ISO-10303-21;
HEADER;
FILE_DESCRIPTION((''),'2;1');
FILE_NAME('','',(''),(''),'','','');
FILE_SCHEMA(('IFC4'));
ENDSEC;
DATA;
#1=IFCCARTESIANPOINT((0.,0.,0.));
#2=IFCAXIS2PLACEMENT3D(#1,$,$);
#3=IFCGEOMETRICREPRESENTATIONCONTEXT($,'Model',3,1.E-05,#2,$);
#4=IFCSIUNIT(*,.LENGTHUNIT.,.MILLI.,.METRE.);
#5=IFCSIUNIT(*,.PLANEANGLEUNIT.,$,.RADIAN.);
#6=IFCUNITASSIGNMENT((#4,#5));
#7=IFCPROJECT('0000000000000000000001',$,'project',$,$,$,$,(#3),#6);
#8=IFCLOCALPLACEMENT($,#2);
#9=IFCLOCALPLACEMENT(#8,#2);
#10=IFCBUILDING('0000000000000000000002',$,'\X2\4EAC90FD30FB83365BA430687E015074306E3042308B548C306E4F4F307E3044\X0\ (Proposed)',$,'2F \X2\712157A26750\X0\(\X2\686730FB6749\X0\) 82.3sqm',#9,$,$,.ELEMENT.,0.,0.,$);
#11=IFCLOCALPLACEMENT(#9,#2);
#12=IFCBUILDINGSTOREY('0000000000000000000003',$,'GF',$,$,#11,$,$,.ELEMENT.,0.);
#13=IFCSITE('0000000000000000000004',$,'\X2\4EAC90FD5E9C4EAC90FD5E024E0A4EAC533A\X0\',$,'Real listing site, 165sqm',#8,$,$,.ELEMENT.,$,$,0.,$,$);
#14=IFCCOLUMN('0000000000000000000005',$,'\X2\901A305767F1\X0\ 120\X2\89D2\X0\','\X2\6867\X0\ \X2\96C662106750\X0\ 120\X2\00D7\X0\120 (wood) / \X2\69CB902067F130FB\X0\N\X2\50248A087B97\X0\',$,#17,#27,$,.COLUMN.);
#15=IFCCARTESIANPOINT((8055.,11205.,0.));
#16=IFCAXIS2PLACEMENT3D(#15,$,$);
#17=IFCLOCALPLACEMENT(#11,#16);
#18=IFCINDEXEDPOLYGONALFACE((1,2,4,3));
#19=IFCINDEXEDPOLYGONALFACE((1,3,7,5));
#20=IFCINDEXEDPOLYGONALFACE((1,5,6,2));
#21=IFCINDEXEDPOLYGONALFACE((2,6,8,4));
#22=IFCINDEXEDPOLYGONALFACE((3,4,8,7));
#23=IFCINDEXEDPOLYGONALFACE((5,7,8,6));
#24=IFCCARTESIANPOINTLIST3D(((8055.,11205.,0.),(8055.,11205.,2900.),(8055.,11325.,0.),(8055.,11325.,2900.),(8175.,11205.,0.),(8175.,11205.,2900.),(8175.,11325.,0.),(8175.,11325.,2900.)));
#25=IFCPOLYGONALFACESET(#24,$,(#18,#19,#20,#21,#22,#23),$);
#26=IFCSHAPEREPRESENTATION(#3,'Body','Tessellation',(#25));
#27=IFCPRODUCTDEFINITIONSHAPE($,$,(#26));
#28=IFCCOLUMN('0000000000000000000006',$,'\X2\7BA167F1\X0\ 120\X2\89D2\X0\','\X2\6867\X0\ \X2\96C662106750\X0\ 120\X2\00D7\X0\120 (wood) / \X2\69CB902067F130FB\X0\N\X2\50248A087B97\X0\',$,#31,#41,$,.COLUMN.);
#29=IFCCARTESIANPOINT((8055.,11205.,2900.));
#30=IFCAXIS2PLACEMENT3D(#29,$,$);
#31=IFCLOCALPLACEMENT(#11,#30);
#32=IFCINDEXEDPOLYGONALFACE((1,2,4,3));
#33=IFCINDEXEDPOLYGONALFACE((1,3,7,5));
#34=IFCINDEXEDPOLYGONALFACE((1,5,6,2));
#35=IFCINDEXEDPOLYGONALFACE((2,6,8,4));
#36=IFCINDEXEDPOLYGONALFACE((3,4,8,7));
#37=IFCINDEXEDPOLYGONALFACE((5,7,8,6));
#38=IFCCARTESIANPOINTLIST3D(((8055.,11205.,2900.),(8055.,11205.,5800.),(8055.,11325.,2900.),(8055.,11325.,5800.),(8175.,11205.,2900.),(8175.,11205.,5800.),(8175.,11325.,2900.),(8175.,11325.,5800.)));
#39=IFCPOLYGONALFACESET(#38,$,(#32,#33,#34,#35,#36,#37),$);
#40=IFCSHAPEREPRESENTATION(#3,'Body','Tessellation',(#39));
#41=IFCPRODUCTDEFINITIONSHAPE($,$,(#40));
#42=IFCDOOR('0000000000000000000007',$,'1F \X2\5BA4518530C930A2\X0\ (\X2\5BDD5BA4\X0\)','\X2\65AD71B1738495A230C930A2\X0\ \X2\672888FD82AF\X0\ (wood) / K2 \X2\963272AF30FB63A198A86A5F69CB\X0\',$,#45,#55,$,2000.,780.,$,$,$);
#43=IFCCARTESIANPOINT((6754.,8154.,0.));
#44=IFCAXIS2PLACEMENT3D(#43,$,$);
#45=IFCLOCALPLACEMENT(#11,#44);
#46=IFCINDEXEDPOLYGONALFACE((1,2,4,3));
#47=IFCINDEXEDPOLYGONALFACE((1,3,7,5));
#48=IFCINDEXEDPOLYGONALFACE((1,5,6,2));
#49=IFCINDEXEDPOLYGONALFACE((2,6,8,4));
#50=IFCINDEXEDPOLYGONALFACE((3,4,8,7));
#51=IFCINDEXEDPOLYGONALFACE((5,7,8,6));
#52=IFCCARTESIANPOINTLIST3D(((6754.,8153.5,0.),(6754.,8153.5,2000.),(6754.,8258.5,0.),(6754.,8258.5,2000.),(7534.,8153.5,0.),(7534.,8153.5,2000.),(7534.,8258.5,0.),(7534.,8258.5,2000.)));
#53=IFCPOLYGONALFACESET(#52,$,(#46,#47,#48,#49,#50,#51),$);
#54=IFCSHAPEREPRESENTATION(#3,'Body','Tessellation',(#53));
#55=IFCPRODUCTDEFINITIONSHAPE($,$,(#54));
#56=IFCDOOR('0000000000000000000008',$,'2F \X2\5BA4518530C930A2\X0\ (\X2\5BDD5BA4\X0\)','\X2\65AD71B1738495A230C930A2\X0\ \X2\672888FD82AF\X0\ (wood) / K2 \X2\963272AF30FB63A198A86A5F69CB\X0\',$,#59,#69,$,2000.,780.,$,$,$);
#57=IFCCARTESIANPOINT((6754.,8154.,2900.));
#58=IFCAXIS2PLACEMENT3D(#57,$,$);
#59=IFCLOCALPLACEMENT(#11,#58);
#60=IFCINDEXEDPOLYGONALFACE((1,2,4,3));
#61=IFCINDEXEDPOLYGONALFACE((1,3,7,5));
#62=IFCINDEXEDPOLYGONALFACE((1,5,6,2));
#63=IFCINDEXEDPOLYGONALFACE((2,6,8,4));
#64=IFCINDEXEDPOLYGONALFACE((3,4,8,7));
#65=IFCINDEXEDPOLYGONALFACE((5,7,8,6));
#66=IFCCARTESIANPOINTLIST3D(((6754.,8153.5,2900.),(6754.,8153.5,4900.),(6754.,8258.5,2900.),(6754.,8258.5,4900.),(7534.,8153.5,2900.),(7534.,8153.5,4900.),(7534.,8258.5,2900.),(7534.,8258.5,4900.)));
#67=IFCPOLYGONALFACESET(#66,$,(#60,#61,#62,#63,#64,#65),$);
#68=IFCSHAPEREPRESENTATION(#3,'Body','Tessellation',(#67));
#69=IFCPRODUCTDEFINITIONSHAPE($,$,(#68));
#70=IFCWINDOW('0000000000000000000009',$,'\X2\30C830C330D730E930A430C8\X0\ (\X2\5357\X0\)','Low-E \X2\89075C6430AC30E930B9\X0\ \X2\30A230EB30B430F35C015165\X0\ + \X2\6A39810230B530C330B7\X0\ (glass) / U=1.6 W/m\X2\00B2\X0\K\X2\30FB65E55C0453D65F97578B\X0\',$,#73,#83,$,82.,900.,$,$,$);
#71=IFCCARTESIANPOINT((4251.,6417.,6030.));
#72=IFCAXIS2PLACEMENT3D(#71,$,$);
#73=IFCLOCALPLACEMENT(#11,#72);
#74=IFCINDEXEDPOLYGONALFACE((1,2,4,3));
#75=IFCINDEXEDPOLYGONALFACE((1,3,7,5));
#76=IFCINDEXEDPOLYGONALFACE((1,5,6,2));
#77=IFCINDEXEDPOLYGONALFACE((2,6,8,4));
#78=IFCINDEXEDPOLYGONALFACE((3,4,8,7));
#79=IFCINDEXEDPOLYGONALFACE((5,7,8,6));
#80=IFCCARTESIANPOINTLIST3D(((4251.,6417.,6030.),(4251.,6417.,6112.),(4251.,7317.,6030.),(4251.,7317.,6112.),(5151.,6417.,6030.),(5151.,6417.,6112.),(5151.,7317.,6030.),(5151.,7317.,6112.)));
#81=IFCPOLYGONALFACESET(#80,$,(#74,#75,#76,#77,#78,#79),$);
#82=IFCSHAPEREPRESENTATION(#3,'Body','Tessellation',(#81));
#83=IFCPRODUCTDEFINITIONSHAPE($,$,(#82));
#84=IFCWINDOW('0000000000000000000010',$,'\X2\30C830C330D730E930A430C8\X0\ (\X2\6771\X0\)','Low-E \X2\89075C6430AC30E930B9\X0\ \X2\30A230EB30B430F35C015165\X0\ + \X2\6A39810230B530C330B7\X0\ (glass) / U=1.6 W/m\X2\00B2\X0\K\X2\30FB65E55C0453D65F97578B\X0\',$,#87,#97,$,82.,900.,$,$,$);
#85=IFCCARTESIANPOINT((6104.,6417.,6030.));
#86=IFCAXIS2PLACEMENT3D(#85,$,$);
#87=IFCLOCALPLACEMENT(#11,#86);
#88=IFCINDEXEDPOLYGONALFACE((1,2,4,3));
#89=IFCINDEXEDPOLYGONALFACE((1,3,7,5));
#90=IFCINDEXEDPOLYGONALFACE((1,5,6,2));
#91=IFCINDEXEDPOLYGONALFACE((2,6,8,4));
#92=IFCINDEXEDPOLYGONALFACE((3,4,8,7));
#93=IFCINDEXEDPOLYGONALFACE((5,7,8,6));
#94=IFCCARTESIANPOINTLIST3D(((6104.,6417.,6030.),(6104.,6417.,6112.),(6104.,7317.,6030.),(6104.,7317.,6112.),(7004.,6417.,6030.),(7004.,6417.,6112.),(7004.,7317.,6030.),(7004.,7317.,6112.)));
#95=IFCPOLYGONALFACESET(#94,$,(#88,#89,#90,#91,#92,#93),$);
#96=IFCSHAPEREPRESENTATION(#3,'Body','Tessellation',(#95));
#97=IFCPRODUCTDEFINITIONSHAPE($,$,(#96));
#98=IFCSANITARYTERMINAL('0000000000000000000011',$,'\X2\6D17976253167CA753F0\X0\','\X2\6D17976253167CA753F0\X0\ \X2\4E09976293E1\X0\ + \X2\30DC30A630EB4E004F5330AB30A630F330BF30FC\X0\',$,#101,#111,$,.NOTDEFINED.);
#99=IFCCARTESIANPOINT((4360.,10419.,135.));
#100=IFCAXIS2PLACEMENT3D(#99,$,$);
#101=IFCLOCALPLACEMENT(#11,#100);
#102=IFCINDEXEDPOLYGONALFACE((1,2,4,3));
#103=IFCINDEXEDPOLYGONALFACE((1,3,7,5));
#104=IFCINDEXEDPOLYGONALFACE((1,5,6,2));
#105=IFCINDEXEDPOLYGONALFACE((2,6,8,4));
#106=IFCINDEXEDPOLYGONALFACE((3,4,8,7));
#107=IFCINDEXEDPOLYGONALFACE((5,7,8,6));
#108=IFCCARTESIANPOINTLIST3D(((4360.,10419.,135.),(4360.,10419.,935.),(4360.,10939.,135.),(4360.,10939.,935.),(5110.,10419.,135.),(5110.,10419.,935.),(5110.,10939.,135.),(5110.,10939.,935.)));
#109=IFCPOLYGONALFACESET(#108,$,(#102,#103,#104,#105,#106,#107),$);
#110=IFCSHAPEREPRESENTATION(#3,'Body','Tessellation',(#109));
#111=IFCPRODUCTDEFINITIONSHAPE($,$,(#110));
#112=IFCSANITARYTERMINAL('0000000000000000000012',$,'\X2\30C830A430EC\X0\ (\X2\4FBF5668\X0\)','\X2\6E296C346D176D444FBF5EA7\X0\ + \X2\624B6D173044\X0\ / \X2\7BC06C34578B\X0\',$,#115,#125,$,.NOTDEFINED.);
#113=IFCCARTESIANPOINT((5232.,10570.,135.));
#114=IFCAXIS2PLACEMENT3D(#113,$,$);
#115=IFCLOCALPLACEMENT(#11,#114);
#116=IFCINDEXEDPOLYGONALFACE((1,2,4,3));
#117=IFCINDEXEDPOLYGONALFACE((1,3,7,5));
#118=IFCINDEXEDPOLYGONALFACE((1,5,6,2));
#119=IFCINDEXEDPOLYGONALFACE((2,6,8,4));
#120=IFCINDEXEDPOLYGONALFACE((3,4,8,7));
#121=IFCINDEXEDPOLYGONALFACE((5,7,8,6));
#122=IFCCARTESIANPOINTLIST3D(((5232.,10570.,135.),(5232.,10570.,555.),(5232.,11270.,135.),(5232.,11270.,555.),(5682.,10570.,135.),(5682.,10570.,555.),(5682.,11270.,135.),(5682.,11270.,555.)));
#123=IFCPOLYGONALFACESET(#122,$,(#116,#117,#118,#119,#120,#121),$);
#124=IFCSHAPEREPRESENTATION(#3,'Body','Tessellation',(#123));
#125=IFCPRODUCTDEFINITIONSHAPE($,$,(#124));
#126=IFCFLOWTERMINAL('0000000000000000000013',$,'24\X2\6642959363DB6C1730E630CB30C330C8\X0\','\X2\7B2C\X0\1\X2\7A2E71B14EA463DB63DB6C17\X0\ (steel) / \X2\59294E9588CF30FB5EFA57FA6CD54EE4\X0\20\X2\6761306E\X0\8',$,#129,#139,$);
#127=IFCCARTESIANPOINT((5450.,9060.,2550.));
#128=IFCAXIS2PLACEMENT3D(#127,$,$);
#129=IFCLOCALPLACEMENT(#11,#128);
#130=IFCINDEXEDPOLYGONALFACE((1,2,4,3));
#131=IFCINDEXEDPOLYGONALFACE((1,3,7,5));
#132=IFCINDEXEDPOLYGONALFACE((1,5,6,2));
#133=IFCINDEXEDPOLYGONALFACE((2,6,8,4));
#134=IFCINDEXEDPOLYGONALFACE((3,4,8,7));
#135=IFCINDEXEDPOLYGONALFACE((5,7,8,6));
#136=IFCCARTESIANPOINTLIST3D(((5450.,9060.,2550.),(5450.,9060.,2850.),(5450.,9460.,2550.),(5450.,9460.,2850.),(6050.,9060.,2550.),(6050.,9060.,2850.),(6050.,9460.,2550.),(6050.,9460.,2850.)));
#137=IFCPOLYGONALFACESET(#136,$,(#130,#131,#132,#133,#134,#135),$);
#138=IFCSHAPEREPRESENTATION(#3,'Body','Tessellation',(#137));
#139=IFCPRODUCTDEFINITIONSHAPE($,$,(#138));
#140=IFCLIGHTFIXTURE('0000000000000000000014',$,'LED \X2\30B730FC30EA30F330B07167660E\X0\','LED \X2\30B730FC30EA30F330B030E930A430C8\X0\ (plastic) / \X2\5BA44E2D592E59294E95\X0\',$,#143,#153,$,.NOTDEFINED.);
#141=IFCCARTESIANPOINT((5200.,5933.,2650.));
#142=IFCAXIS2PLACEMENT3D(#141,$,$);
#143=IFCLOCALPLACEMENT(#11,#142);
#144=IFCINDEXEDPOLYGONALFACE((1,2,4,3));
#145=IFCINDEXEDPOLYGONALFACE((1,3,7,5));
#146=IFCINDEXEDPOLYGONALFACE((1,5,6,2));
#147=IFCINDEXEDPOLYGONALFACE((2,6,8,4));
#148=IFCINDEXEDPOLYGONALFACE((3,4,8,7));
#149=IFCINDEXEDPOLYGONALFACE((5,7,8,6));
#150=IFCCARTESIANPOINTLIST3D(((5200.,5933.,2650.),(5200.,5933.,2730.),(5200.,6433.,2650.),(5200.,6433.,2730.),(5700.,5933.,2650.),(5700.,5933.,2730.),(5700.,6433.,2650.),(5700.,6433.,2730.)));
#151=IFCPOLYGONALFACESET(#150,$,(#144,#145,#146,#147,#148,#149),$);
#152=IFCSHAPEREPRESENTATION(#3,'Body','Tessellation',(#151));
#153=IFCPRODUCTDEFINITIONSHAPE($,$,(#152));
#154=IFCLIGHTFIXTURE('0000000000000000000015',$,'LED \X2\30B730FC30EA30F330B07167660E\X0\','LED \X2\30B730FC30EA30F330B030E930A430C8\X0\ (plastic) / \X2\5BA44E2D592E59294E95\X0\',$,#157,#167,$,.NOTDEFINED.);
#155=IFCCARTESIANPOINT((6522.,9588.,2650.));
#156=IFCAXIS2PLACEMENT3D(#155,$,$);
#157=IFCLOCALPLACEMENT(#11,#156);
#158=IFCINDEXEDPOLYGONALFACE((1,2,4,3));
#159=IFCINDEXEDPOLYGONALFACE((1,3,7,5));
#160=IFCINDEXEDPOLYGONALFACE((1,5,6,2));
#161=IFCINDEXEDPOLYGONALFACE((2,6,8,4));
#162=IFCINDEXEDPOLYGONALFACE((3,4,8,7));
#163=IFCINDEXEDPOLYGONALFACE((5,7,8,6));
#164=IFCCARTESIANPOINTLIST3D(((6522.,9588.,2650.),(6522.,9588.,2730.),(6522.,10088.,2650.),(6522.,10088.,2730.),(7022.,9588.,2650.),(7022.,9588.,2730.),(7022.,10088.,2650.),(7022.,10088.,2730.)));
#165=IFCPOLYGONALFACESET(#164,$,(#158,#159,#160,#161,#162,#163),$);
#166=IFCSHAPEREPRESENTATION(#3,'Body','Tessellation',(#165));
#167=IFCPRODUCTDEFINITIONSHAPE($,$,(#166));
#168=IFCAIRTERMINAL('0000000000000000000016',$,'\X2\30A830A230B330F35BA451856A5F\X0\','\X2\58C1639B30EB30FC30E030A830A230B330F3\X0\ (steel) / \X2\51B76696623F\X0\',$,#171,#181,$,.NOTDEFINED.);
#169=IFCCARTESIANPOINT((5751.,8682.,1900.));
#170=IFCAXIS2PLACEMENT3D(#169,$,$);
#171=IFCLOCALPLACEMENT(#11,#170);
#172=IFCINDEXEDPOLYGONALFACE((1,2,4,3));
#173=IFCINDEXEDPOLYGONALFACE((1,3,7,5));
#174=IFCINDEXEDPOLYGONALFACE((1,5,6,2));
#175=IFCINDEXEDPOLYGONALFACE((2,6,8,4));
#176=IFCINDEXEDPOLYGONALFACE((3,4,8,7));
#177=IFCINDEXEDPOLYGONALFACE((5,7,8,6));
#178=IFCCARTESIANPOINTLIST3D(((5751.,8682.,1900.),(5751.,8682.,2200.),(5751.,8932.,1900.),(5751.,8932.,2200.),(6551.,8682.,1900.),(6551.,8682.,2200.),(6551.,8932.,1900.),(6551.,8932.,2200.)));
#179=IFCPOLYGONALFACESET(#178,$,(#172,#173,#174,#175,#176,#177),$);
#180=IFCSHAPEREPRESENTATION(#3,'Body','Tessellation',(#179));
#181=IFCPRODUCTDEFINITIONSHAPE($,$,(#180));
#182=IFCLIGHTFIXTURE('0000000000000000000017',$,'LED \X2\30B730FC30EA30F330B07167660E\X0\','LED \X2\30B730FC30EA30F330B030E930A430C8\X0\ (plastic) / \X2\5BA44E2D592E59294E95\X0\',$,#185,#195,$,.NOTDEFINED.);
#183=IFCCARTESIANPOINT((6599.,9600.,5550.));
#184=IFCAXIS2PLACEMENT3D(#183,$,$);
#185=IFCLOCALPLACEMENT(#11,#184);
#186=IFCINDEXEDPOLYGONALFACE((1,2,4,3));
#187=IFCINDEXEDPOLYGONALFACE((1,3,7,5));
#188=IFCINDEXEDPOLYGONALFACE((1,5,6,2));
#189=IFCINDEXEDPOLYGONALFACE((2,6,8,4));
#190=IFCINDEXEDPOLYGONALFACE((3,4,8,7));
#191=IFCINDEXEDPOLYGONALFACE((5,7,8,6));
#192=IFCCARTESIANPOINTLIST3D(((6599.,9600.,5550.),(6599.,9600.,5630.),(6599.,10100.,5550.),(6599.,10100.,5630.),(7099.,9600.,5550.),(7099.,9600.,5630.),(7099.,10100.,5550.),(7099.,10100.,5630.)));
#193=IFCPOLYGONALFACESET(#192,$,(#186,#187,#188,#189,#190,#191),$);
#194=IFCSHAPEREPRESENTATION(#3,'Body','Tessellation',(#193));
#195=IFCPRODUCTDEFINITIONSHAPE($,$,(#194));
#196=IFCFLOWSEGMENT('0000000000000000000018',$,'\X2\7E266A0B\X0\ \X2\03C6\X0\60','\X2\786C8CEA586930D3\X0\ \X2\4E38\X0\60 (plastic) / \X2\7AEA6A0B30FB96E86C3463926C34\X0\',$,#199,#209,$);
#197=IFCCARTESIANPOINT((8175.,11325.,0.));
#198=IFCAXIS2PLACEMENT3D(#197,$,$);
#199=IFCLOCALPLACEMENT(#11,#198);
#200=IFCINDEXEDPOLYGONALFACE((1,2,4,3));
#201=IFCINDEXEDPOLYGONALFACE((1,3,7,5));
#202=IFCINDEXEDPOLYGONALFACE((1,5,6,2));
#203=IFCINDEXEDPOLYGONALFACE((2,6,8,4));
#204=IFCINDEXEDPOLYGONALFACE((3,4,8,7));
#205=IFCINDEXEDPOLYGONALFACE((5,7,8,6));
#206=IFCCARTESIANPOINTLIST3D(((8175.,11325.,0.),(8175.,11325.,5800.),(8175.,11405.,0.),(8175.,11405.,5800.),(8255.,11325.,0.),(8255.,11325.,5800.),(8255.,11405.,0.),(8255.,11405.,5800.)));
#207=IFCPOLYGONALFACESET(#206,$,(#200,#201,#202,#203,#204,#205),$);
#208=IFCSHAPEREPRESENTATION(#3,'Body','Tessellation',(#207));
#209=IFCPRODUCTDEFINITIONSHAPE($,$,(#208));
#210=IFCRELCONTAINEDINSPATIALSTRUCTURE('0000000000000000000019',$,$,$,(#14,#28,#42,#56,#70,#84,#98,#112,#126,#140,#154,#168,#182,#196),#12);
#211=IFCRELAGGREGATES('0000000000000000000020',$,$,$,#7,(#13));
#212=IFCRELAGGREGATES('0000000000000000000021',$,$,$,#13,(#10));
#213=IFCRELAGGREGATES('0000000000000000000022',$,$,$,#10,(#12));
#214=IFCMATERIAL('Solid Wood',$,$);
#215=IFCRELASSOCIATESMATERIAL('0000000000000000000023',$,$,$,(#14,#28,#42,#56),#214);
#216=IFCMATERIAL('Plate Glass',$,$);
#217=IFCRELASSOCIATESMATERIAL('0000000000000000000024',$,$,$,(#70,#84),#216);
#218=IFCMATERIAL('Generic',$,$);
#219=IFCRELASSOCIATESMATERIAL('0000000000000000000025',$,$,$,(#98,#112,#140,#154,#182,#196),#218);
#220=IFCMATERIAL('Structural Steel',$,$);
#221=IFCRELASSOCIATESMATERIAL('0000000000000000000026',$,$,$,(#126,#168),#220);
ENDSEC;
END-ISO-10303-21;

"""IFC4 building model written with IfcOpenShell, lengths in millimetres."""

from ifc_helpers import new_model, si_unit, frame, frame_2d, origin, place, context, project, spatial, rectangle, extrude, material, element, save


model = new_model("IFC4")

# Units and contexts
model_context = context("Model", 3, precision=1e-05, world=origin())
ifc_project = project(units=[si_unit("LENGTHUNIT", "METRE", prefix="MILLI"), si_unit("PLANEANGLEUNIT", "RADIAN")], contexts=[model_context])

# Site, building, storey
site_placement = place(None, origin())
site = spatial("IfcSite", under=ifc_project, at=site_placement, Name="京都府京都市上京区", ObjectType="Real listing site, 165sqm", CompositionType="ELEMENT", RefElevation=0.0)
building_placement = place(site_placement, origin())
building = spatial("IfcBuilding", under=site, at=building_placement, Name="京都・茶室と縁側のある和の住まい (Proposed)", ObjectType="2F 無垢材(桧・杉) 82.3sqm", CompositionType="ELEMENT", ElevationOfRefHeight=0.0, ElevationOfTerrain=0.0)
storey_placement = place(building_placement, origin())
storey = spatial("IfcBuildingStorey", under=building, at=storey_placement, Name="GF", CompositionType="ELEMENT", Elevation=0.0)

# Columns
ifc_material_1 = material(Name="Solid Wood")
column_1_placement = place(storey_placement, frame((8055.0, 11205.0, 0.0)))
element("IfcColumn", 1, at=column_1_placement, inside=storey, material=ifc_material_1, Name="通し柱 120角", Description="桧 集成材 120×120 (wood) / 構造柱・N値計算", PredefinedType="COLUMN", context=model_context, shape_type="SweptSolid", body=[
    extrude(rectangle(XDim=120.0, YDim=120.0, at=frame_2d((60.0, 60.0))), frame((8055.0, 11205.0, 0.0)), (0.0, 0.0, 1.0), 2900.0),
])
column_2_placement = place(storey_placement, frame((8055.0, 11205.0, 2900.0)))
element("IfcColumn", 2, at=column_2_placement, inside=storey, material=ifc_material_1, Name="管柱 120角", Description="桧 集成材 120×120 (wood) / 構造柱・N値計算", PredefinedType="COLUMN", context=model_context, shape_type="SweptSolid", body=[
    extrude(rectangle(XDim=120.0, YDim=120.0, at=frame_2d((60.0, 60.0))), frame((8055.0, 11205.0, 2900.0)), (0.0, 0.0, 1.0), 2900.0),
])

# Door
door_1_placement = place(storey_placement, frame((6754.0, 8154.0, 0.0)))
element("IfcDoor", 3, at=door_1_placement, inside=storey, material=ifc_material_1, Name="1F 室内ドア (寝室)", Description="断熱玄関ドア 木製芯 (wood) / K2 防犯・採風機構", OverallHeight=2000.0, OverallWidth=780.0, context=model_context, shape_type="SweptSolid", body=[
    extrude(rectangle(XDim=780.0, YDim=105.0, at=frame_2d((390.0, 52.0))), frame((6754.0, 8154.0, 0.0)), (0.0, 0.0, 1.0), 2000.0),
])

# Door
door_2_placement = place(storey_placement, frame((6754.0, 8154.0, 2900.0)))
element("IfcDoor", 4, at=door_2_placement, inside=storey, material=ifc_material_1, Name="2F 室内ドア (寝室)", Description="断熱玄関ドア 木製芯 (wood) / K2 防犯・採風機構", OverallHeight=2000.0, OverallWidth=780.0, context=model_context, shape_type="SweptSolid", body=[
    extrude(rectangle(XDim=780.0, YDim=105.0, at=frame_2d((390.0, 52.0))), frame((6754.0, 8154.0, 2900.0)), (0.0, 0.0, 1.0), 2000.0),
])

# Windows
ifc_material_2 = material(Name="Plate Glass")
window_1_placement = place(storey_placement, frame((4251.0, 6417.0, 6030.0)))
element("IfcWindow", 5, at=window_1_placement, inside=storey, material=ifc_material_2, Name="トップライト (南)", Description="Low-E 複層ガラス アルゴン封入 + 樹脂サッシ (glass) / U=1.6 W/m²K・日射取得型", OverallHeight=82.0, OverallWidth=900.0, context=model_context, shape_type="SweptSolid", body=[
    extrude(rectangle(XDim=900.0, YDim=900.0, at=frame_2d((450.0, 450.0))), frame((4251.0, 6417.0, 6030.0)), (0.0, 0.0, 1.0), 82.0),
])
window_2_placement = place(storey_placement, frame((6104.0, 6417.0, 6030.0)))
element("IfcWindow", 6, at=window_2_placement, inside=storey, material=ifc_material_2, Name="トップライト (東)", Description="Low-E 複層ガラス アルゴン封入 + 樹脂サッシ (glass) / U=1.6 W/m²K・日射取得型", OverallHeight=82.0, OverallWidth=900.0, context=model_context, shape_type="SweptSolid", body=[
    extrude(rectangle(XDim=900.0, YDim=900.0, at=frame_2d((450.0, 450.0))), frame((6104.0, 6417.0, 6030.0)), (0.0, 0.0, 1.0), 82.0),
])

# Sanitary terminals
ifc_material_3 = material(Name="Generic")
sanitary_terminal_1_placement = place(storey_placement, frame((4360.0, 10419.0, 135.0)))
element("IfcSanitaryTerminal", 7, at=sanitary_terminal_1_placement, inside=storey, material=ifc_material_3, Name="洗面化粧台", Description="洗面化粧台 三面鏡 + ボウル一体カウンター", PredefinedType="NOTDEFINED", context=model_context, shape_type="SweptSolid", body=[
    extrude(rectangle(XDim=750.0, YDim=520.0, at=frame_2d((375.0, 260.0))), frame((4360.0, 10419.0, 135.0)), (0.0, 0.0, 1.0), 800.0),
])
sanitary_terminal_2_placement = place(storey_placement, frame((5232.0, 10570.0, 135.0)))
element("IfcSanitaryTerminal", 8, at=sanitary_terminal_2_placement, inside=storey, material=ifc_material_3, Name="トイレ (便器)", Description="温水洗浄便座 + 手洗い / 節水型", PredefinedType="NOTDEFINED", context=model_context, shape_type="SweptSolid", body=[
    extrude(rectangle(XDim=450.0, YDim=700.0, at=frame_2d((225.0, 350.0))), frame((5232.0, 10570.0, 135.0)), (0.0, 0.0, 1.0), 420.0),
])

# Flow terminal
ifc_material_4 = material(Name="Structural Steel")
flow_terminal_placement = place(storey_placement, frame((5450.0, 9060.0, 2550.0)))
element("IfcFlowTerminal", 9, at=flow_terminal_placement, inside=storey, material=ifc_material_4, Name="24時間換気ユニット", Description="第1種熱交換換気 (steel) / 天井裏・建基法令20条の8", context=model_context, shape_type="SweptSolid", body=[
    extrude(rectangle(XDim=600.0, YDim=400.0, at=frame_2d((300.0, 200.0))), frame((5450.0, 9060.0, 2550.0)), (0.0, 0.0, 1.0), 300.0),
])

# Light fixtures
light_fixture_1_placement = place(storey_placement, frame((5200.0, 5933.0, 2650.0)))
element("IfcLightFixture", 10, at=light_fixture_1_placement, inside=storey, material=ifc_material_3, Name="LED シーリング照明", Description="LED シーリングライト (plastic) / 室中央天井", PredefinedType="NOTDEFINED", context=model_context, shape_type="SweptSolid", body=[
    extrude(rectangle(XDim=500.0, YDim=500.0, at=frame_2d((250.0, 250.0))), frame((5200.0, 5933.0, 2650.0)), (0.0, 0.0, 1.0), 80.0),
])
light_fixture_2_placement = place(storey_placement, frame((6522.0, 9588.0, 2650.0)))
element("IfcLightFixture", 11, at=light_fixture_2_placement, inside=storey, material=ifc_material_3, Name="LED シーリング照明", Description="LED シーリングライト (plastic) / 室中央天井", PredefinedType="NOTDEFINED", context=model_context, shape_type="SweptSolid", body=[
    extrude(rectangle(XDim=500.0, YDim=500.0, at=frame_2d((250.0, 250.0))), frame((6522.0, 9588.0, 2650.0)), (0.0, 0.0, 1.0), 80.0),
])

# Air terminal
air_terminal_placement = place(storey_placement, frame((5751.0, 8682.0, 1900.0)))
element("IfcAirTerminal", 12, at=air_terminal_placement, inside=storey, material=ifc_material_4, Name="エアコン室内機", Description="壁掛ルームエアコン (steel) / 冷暖房", PredefinedType="NOTDEFINED", context=model_context, shape_type="SweptSolid", body=[
    extrude(rectangle(XDim=800.0, YDim=250.0, at=frame_2d((400.0, 125.0))), frame((5751.0, 8682.0, 1900.0)), (0.0, 0.0, 1.0), 300.0),
])

# Light fixture
light_fixture_3_placement = place(storey_placement, frame((6599.0, 9600.0, 5550.0)))
element("IfcLightFixture", 13, at=light_fixture_3_placement, inside=storey, material=ifc_material_3, Name="LED シーリング照明", Description="LED シーリングライト (plastic) / 室中央天井", PredefinedType="NOTDEFINED", context=model_context, shape_type="SweptSolid", body=[
    extrude(rectangle(XDim=500.0, YDim=500.0, at=frame_2d((250.0, 250.0))), frame((6599.0, 9600.0, 5550.0)), (0.0, 0.0, 1.0), 80.0),
])

# Flow segment
flow_segment_placement = place(storey_placement, frame((8175.0, 11325.0, 0.0)))
element("IfcFlowSegment", 14, at=flow_segment_placement, inside=storey, material=ifc_material_3, Name="縦樋 φ60", Description="硬質塩ビ 丸60 (plastic) / 竪樋・雨水排水", context=model_context, shape_type="SweptSolid", body=[
    extrude(rectangle(XDim=80.0, YDim=80.0, at=frame_2d((40.0, 40.0))), frame((8175.0, 11325.0, 0.0)), (0.0, 0.0, 1.0), 5800.0),
])

save(model, "model.ifc")
